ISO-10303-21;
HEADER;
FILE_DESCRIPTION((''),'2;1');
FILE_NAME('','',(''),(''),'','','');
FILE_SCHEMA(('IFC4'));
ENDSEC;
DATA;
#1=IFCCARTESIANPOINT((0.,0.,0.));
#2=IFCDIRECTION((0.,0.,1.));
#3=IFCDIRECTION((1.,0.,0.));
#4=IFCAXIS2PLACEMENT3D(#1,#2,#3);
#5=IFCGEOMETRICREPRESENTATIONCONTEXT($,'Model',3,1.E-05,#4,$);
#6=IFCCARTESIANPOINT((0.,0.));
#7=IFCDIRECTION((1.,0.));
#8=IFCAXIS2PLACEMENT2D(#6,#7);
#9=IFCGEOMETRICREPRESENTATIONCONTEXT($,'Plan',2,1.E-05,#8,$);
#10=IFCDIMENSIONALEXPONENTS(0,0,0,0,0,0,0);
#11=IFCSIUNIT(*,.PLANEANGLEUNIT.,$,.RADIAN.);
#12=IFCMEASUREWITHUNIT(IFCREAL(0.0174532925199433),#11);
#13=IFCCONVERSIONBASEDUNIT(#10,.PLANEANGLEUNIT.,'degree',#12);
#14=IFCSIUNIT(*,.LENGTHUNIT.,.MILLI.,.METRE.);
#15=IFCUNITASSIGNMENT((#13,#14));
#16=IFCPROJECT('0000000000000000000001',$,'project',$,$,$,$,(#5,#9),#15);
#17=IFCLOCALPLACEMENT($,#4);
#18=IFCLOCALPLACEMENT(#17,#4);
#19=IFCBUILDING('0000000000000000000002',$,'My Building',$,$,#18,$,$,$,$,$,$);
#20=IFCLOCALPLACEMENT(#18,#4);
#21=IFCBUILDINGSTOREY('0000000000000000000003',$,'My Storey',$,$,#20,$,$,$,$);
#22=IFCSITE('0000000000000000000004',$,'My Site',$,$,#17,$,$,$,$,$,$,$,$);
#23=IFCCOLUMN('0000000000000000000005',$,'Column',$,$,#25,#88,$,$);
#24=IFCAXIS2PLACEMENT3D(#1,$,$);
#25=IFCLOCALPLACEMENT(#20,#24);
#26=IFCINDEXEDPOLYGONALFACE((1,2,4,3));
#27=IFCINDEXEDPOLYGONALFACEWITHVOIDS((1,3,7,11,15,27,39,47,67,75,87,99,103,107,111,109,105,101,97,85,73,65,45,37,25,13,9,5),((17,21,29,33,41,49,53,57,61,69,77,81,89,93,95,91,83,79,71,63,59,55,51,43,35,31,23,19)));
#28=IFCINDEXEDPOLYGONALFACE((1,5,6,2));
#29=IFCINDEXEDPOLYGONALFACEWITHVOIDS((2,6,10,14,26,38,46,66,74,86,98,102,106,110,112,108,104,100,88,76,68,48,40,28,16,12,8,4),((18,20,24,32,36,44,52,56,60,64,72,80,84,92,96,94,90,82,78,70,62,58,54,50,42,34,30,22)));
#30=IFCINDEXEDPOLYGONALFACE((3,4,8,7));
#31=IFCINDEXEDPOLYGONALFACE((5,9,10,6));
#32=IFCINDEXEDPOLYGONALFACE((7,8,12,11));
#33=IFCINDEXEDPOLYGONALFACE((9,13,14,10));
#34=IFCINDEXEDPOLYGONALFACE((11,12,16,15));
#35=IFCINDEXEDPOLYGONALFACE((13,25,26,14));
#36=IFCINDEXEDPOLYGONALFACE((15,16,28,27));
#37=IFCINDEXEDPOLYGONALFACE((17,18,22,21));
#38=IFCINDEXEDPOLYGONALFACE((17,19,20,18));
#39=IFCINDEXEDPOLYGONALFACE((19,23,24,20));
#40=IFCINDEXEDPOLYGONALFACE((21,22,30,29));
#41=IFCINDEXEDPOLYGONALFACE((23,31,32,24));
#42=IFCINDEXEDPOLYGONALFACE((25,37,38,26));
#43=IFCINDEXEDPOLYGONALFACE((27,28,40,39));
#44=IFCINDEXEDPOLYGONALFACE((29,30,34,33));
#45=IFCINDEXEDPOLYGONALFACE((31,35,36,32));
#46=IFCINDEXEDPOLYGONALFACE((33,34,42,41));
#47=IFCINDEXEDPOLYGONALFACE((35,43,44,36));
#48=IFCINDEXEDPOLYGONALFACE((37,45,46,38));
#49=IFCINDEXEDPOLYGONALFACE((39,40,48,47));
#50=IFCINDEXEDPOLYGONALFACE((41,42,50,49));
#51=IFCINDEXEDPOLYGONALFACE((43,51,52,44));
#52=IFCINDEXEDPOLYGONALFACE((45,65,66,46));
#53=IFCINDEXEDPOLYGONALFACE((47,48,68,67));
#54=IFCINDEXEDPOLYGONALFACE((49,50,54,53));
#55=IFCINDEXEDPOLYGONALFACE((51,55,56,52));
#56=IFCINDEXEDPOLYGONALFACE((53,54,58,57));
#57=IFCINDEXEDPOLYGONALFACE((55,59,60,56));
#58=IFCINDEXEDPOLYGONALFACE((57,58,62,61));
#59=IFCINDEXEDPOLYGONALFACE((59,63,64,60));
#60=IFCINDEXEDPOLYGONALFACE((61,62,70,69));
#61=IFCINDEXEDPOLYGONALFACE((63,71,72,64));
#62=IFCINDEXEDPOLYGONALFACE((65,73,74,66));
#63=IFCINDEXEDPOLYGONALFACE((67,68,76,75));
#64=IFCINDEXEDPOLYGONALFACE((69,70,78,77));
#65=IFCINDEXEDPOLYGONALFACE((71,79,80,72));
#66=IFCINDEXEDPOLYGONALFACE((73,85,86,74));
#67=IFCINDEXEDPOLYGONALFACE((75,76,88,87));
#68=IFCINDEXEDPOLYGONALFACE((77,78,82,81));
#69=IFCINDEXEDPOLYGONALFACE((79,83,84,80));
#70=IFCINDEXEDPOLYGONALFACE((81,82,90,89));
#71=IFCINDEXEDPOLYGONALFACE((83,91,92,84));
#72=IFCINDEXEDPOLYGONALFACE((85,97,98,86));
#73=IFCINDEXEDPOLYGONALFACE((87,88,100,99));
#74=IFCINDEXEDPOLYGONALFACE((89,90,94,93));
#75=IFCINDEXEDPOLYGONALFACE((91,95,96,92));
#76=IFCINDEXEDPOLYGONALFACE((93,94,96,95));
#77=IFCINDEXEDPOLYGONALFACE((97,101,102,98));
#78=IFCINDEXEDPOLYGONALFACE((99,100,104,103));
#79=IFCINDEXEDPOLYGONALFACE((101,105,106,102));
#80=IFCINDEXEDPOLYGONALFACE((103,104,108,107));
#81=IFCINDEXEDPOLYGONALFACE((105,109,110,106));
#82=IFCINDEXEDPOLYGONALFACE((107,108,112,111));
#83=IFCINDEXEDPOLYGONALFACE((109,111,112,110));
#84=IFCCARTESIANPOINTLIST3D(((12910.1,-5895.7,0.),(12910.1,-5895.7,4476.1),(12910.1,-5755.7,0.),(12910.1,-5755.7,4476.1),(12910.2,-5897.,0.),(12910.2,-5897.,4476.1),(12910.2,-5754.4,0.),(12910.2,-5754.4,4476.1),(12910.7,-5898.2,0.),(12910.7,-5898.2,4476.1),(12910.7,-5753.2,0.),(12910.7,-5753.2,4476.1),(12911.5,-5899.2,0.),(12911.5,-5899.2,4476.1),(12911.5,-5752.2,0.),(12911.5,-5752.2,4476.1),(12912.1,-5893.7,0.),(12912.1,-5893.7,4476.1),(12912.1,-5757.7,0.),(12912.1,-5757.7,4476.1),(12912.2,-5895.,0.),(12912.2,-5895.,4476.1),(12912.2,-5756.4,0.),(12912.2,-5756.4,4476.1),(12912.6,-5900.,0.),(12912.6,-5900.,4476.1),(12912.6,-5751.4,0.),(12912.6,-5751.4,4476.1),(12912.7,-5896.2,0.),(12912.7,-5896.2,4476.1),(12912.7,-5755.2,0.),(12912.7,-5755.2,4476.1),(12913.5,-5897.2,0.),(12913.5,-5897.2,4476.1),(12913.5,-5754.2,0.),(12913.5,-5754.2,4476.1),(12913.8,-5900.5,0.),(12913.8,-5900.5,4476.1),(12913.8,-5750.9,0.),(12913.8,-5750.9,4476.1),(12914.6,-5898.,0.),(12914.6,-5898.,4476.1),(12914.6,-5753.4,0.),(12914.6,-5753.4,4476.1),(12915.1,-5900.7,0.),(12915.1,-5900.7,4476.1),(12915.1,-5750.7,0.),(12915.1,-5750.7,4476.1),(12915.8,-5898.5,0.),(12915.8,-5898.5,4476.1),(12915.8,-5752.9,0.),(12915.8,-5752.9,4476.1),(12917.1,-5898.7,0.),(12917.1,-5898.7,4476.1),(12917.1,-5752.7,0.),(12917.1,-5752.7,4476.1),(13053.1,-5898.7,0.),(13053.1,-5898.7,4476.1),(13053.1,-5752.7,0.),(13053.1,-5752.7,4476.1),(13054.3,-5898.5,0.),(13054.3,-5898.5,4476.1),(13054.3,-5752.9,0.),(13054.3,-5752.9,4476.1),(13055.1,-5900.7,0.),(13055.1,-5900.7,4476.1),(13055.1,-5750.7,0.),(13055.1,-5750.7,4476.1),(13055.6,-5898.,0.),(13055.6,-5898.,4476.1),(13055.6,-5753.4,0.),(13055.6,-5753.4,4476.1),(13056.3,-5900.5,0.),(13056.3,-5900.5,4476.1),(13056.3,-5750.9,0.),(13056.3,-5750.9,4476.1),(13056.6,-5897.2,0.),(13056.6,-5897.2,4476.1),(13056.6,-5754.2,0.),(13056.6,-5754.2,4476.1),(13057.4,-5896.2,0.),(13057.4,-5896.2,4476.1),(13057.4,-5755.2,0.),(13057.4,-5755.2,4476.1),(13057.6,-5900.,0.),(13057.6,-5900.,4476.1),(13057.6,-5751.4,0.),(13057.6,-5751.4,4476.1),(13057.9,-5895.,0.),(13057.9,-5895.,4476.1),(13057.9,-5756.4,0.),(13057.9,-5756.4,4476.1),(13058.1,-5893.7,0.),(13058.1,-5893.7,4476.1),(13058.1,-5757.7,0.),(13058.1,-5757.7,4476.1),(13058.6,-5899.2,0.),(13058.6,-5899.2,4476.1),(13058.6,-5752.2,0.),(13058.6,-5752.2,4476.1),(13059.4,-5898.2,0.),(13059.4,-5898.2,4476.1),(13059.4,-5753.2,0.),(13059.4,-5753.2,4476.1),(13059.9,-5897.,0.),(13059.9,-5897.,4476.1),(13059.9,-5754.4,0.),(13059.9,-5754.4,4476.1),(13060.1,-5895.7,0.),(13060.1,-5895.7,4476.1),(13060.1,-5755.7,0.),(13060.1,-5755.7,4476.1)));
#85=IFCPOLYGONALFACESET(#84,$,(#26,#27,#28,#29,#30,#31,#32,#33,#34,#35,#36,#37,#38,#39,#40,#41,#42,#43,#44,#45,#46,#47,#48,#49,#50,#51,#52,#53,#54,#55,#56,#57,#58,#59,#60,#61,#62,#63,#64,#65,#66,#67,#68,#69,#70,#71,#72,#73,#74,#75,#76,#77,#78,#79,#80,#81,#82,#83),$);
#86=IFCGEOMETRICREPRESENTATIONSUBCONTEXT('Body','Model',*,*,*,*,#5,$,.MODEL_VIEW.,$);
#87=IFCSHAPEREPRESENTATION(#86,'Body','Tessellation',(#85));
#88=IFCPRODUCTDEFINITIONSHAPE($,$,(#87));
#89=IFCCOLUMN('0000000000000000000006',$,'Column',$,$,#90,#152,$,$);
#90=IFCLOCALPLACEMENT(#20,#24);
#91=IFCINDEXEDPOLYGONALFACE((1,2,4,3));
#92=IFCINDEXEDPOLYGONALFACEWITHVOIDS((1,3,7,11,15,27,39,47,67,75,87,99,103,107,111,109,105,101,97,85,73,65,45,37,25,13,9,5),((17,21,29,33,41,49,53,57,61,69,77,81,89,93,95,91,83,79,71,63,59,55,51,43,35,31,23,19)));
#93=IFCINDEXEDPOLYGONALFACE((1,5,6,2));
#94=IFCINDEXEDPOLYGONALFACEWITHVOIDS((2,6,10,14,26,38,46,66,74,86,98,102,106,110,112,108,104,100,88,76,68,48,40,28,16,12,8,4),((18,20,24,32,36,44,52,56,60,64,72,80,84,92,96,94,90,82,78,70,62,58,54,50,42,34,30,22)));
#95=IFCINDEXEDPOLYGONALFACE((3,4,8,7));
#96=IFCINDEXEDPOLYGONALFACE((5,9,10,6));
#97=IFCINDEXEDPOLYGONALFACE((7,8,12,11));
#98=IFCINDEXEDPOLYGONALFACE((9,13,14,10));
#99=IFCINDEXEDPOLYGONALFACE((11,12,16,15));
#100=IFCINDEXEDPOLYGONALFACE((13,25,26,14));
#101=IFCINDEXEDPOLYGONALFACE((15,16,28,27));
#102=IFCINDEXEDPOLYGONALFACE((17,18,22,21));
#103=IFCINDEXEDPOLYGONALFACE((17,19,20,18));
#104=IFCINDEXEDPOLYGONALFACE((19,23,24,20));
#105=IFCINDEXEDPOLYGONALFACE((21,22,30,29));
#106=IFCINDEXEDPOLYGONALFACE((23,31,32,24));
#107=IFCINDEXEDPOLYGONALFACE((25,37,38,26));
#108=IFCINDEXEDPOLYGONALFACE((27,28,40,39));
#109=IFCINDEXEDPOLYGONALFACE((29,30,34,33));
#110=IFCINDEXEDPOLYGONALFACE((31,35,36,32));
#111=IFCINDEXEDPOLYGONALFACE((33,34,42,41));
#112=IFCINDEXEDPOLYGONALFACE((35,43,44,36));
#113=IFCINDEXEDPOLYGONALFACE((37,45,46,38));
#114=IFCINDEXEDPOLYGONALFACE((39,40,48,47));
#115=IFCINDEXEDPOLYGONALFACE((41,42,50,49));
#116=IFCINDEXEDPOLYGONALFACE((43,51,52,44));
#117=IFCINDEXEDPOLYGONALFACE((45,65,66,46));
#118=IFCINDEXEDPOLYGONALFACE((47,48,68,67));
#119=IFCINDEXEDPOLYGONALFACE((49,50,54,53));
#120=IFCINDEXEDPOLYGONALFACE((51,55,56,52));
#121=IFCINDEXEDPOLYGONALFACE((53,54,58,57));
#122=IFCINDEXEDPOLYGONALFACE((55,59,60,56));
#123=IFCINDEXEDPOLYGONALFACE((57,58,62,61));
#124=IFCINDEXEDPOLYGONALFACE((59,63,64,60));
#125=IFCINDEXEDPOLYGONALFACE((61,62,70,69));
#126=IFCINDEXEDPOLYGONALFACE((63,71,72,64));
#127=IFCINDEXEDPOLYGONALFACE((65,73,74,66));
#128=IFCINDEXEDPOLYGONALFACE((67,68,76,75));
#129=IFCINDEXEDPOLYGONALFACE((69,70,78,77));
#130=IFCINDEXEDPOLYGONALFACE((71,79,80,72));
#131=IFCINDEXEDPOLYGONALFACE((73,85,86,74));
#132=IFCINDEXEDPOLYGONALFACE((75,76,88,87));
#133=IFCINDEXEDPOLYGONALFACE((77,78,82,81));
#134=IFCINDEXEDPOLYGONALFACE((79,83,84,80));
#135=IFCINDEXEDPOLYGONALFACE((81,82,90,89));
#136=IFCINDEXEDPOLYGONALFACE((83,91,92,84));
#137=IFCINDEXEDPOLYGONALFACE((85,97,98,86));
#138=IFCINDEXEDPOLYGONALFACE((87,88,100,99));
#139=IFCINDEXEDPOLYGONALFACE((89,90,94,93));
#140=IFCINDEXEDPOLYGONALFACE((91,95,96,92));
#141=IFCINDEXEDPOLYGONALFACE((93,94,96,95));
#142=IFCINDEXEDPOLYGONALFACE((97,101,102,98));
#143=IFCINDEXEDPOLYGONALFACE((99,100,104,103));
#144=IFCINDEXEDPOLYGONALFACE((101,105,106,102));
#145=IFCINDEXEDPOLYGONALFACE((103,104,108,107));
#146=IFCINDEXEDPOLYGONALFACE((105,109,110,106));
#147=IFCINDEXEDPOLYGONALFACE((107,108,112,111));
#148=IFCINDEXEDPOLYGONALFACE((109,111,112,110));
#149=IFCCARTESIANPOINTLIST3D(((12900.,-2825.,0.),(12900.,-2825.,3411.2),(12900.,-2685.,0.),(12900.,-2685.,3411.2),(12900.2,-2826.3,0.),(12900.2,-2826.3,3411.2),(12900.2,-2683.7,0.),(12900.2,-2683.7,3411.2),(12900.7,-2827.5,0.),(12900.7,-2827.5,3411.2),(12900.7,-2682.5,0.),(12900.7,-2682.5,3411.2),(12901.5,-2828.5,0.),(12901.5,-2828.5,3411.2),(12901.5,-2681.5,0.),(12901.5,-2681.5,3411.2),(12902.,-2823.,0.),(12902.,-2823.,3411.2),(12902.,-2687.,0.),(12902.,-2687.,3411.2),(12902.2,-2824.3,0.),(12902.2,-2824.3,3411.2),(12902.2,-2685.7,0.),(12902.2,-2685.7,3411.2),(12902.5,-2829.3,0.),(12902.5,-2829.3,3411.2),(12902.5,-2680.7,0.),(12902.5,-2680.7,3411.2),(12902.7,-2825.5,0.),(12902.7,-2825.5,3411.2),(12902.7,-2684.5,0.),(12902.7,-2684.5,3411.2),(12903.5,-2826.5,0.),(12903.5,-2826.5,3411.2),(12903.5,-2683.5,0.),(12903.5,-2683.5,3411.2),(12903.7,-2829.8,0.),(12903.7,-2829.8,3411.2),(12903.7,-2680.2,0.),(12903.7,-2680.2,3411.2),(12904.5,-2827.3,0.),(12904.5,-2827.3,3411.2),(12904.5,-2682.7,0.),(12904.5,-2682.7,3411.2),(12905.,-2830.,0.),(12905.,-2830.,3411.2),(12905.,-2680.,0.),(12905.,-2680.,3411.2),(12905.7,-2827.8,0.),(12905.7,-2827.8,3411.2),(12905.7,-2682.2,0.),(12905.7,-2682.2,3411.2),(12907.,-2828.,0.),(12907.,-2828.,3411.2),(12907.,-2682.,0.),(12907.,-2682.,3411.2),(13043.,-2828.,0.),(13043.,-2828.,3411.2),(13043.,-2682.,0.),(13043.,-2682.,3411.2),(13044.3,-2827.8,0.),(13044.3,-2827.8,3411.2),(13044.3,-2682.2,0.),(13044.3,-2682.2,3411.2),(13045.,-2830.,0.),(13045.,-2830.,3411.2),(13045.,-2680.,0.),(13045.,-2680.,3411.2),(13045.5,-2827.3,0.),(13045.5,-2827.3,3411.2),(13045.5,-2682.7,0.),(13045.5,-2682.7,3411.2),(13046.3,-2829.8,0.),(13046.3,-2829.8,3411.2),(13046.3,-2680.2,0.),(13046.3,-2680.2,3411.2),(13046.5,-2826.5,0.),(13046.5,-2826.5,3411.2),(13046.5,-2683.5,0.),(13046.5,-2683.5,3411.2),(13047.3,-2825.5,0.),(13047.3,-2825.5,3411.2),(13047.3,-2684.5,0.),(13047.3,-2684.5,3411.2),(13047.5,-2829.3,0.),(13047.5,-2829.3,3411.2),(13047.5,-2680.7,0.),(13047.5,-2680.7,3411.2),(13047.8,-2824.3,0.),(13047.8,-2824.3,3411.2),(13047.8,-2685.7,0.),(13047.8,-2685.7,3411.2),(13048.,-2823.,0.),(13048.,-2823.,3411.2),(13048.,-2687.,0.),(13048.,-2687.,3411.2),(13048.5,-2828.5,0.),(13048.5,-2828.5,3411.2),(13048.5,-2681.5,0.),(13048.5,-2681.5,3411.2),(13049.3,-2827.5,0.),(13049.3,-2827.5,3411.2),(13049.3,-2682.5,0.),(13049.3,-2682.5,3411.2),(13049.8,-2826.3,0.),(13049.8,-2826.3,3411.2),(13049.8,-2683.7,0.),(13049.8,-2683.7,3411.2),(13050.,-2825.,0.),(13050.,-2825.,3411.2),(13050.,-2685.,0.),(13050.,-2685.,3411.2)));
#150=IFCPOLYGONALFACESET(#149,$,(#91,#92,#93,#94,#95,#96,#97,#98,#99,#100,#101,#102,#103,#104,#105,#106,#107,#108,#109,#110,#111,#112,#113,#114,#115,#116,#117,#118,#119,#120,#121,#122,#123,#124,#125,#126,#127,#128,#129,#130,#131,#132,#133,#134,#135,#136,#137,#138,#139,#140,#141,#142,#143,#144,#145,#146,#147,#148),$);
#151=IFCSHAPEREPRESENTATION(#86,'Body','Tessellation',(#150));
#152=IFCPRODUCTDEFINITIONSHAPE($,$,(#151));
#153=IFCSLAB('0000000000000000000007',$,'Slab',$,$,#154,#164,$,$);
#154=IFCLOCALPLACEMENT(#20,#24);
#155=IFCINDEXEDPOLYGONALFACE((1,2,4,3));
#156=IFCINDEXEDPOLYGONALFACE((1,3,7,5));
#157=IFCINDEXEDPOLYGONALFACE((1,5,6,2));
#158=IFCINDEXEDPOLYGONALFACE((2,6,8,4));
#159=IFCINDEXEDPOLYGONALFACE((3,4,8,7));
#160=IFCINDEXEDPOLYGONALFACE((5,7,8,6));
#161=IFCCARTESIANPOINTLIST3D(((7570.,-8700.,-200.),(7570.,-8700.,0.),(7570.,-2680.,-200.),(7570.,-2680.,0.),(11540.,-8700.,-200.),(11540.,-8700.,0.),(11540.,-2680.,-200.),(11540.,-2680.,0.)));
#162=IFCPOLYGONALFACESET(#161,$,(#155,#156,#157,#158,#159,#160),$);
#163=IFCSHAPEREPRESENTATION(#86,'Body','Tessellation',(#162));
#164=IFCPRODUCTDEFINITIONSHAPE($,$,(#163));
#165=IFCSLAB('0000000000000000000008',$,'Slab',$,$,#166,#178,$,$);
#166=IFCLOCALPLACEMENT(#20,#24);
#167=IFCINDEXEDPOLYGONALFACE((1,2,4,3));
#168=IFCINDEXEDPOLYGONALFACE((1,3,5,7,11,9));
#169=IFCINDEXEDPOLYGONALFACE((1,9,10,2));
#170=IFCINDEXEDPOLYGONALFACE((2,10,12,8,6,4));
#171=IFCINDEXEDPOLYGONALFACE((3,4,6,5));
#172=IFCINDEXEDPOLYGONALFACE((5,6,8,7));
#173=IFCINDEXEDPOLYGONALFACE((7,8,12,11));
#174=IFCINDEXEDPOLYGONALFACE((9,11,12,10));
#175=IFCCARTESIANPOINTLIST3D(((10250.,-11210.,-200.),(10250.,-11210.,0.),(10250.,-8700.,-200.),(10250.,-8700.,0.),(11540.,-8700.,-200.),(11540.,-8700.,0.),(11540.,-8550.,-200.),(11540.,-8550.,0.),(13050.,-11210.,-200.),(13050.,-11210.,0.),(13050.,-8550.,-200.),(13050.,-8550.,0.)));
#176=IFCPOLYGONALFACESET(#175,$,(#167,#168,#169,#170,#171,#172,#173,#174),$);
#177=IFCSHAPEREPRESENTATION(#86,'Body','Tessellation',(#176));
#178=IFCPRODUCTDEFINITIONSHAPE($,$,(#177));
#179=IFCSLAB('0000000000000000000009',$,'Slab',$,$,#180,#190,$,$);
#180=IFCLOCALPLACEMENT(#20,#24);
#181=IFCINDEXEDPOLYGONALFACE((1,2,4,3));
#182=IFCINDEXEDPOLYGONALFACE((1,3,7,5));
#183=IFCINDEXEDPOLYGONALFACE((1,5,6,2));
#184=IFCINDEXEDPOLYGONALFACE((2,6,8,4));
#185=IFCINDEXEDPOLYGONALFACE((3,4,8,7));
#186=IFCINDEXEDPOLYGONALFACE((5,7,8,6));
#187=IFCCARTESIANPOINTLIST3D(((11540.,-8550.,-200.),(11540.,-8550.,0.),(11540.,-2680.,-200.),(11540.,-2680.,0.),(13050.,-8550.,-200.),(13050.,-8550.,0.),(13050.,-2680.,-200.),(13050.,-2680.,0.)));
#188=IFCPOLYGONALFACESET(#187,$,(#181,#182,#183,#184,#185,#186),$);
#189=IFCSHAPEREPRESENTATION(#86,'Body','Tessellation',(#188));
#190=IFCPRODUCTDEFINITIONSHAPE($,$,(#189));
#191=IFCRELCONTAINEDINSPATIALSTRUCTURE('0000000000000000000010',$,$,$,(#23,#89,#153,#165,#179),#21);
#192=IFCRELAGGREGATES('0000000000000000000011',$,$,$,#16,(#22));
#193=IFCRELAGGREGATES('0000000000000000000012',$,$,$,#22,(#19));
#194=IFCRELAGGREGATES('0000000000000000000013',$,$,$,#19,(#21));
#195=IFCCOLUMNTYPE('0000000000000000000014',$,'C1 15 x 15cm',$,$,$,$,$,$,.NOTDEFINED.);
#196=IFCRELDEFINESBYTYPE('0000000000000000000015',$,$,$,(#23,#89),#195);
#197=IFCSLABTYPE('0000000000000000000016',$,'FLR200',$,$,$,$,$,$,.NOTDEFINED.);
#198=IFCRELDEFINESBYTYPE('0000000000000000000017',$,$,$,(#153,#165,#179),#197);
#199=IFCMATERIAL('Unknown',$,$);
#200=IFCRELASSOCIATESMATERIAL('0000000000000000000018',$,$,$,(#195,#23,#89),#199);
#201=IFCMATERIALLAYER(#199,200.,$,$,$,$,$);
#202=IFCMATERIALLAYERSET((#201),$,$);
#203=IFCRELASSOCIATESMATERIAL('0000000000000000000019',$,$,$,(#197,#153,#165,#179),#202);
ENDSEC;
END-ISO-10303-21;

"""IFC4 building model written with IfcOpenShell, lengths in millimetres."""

from ifc_helpers import new_model, entity, si_unit, converted_unit, frame, origin_with_axes, origin_2d_with_axis, place, context, subcontext, project, spatial, indexed_curve, hollow_rectangle, outline, extrude, material, layer, layer_set, layer_usage, material_profile, profile_set, profile_usage, type_object, element, save


model = new_model("IFC4")

# Units and contexts
model_context = context("Model", 3, precision=1e-05, world=origin_with_axes())
plan_context = context("Plan", 2, precision=1e-05, world=origin_2d_with_axis())
body_context_1 = subcontext(model_context, "Body", "Model", "MODEL_VIEW")
ifc_project = project(units=[converted_unit("PLANEANGLEUNIT", "degree", entity("IfcReal", 0.0174532925199433), si_unit("PLANEANGLEUNIT", "RADIAN"), dimensions=[0, 0, 0, 0, 0, 0, 0]), si_unit("LENGTHUNIT", "METRE", prefix="MILLI")], contexts=[model_context, plan_context])

# Site, building, storey
site_placement = place(None, origin_with_axes())
site = spatial("IfcSite", under=ifc_project, at=site_placement, Name="My Site")
building_placement = place(site_placement, origin_with_axes())
building = spatial("IfcBuilding", under=site, at=building_placement, Name="My Building")
storey_placement = place(building_placement, origin_with_axes())
storey = spatial("IfcBuildingStorey", under=building, at=storey_placement, Name="My Storey")

# Columns
ifc_material = material(Name="Unknown")
ifc_material_profile = material_profile(ifc_material, hollow_rectangle(XDim=150.0, YDim=150.0, WallThickness=2.0, InnerFilletRadius=5.0, OuterFilletRadius=5.0))
ifc_profile_set = profile_set([ifc_material_profile])
ifc_profile_usage_1 = profile_usage(ifc_profile_set, cardinal=5)
column_type = type_object("IfcColumnType", Name="C1 15 x 15cm", PredefinedType="NOTDEFINED", material=ifc_profile_set)
column_1_placement = place(storey_placement, frame((12985.1, -5825.7, 0.0), z_axis=(0.0, 0.0, 1.0), x_axis=(1.0, 0.0, 0.0)))
element("IfcColumn", 1, at=column_1_placement, inside=storey, type_object=column_type, material=ifc_profile_usage_1, Name="Column", context=body_context_1, shape_type="SweptSolid", body=[
    extrude(hollow_rectangle(XDim=150.0, YDim=150.0, WallThickness=2.0, InnerFilletRadius=5.0, OuterFilletRadius=5.0), origin_with_axes(), (0.0, 0.0, 1.0), 4476.1),
])
ifc_profile_usage_2 = profile_usage(ifc_profile_set, cardinal=5)
column_2_placement = place(storey_placement, frame((12975.0, -2755.0, 0.0), z_axis=(0.0, 0.0, 1.0), x_axis=(1.0, 0.0, 0.0)))
element("IfcColumn", 2, at=column_2_placement, inside=storey, type_object=column_type, material=ifc_profile_usage_2, Name="Column", context=body_context_1, shape_type="SweptSolid", body=[
    extrude(hollow_rectangle(XDim=150.0, YDim=150.0, WallThickness=2.0, InnerFilletRadius=5.0, OuterFilletRadius=5.0), origin_with_axes(), (0.0, 0.0, 1.0), 3411.2),
])

# Slabs
ifc_layer_1 = layer(ifc_material, 200.0)
ifc_layer_set_1 = layer_set([ifc_layer_1])
ifc_layer_usage_1 = layer_usage(ifc_layer_set_1, "AXIS3", "POSITIVE", -200.0)
slab_type_1 = type_object("IfcSlabType", Name="FLR200", PredefinedType="NOTDEFINED", material=ifc_layer_set_1)
slab_1_placement = place(storey_placement, frame((7570.0, -8700.0, 0.0), z_axis=(0.0, 0.0, 1.0), x_axis=(1.0, 0.0, 0.0)))
element("IfcSlab", 3, at=slab_1_placement, inside=storey, type_object=slab_type_1, material=ifc_layer_usage_1, Name="Slab", context=body_context_1, shape_type="SweptSolid", body=[
    extrude(outline(indexed_curve([(0.0, 0.0), (3970.0, 0.0), (3970.0, 6020.0), (0.0, 6020.0), (0.0, 0.0)])), frame((0.0, 0.0, -200.0), z_axis=(0.0, 0.0, 1.0), x_axis=(1.0, 0.0, 0.0)), (0.0, 0.0, 1.0), 200.0),
])
ifc_layer_usage_2 = layer_usage(ifc_layer_set_1, "AXIS3", "POSITIVE", -200.0)
slab_2_placement = place(storey_placement, frame((11540.0, -8550.0, 0.0), z_axis=(0.0, 0.0, 1.0), x_axis=(1.0, 0.0, 0.0)))
element("IfcSlab", 4, at=slab_2_placement, inside=storey, type_object=slab_type_1, material=ifc_layer_usage_2, Name="Slab", context=body_context_1, shape_type="SweptSolid", body=[
    extrude(outline(indexed_curve([(0.0, 0.0), (1510.0, 0.0), (1510.0, -2660.0), (-1290.0, -2660.0), (-1290.0, -150.0), (0.0, -150.0), (0.0, 0.0)])), frame((0.0, 0.0, -200.0), z_axis=(0.0, 0.0, 1.0), x_axis=(1.0, 0.0, 0.0)), (0.0, 0.0, 1.0), 200.0),
])
ifc_layer_usage_3 = layer_usage(ifc_layer_set_1, "AXIS3", "POSITIVE", -200.0)
slab_3_placement = place(storey_placement, frame((11540.0, -8550.0, 0.0), z_axis=(0.0, 0.0, 1.0), x_axis=(1.0, 0.0, 0.0)))
element("IfcSlab", 5, at=slab_3_placement, inside=storey, type_object=slab_type_1, material=ifc_layer_usage_3, Name="Slab", context=body_context_1, shape_type="SweptSolid", body=[
    extrude(outline(indexed_curve([(0.0, 0.0), (1510.0, 0.0), (1510.0, 5870.0), (0.0, 5870.0), (0.0, 0.0)])), frame((0.0, 0.0, -200.0), z_axis=(0.0, 0.0, 1.0), x_axis=(1.0, 0.0, 0.0)), (0.0, 0.0, 1.0), 200.0),
])

save(model, "model.ifc")
